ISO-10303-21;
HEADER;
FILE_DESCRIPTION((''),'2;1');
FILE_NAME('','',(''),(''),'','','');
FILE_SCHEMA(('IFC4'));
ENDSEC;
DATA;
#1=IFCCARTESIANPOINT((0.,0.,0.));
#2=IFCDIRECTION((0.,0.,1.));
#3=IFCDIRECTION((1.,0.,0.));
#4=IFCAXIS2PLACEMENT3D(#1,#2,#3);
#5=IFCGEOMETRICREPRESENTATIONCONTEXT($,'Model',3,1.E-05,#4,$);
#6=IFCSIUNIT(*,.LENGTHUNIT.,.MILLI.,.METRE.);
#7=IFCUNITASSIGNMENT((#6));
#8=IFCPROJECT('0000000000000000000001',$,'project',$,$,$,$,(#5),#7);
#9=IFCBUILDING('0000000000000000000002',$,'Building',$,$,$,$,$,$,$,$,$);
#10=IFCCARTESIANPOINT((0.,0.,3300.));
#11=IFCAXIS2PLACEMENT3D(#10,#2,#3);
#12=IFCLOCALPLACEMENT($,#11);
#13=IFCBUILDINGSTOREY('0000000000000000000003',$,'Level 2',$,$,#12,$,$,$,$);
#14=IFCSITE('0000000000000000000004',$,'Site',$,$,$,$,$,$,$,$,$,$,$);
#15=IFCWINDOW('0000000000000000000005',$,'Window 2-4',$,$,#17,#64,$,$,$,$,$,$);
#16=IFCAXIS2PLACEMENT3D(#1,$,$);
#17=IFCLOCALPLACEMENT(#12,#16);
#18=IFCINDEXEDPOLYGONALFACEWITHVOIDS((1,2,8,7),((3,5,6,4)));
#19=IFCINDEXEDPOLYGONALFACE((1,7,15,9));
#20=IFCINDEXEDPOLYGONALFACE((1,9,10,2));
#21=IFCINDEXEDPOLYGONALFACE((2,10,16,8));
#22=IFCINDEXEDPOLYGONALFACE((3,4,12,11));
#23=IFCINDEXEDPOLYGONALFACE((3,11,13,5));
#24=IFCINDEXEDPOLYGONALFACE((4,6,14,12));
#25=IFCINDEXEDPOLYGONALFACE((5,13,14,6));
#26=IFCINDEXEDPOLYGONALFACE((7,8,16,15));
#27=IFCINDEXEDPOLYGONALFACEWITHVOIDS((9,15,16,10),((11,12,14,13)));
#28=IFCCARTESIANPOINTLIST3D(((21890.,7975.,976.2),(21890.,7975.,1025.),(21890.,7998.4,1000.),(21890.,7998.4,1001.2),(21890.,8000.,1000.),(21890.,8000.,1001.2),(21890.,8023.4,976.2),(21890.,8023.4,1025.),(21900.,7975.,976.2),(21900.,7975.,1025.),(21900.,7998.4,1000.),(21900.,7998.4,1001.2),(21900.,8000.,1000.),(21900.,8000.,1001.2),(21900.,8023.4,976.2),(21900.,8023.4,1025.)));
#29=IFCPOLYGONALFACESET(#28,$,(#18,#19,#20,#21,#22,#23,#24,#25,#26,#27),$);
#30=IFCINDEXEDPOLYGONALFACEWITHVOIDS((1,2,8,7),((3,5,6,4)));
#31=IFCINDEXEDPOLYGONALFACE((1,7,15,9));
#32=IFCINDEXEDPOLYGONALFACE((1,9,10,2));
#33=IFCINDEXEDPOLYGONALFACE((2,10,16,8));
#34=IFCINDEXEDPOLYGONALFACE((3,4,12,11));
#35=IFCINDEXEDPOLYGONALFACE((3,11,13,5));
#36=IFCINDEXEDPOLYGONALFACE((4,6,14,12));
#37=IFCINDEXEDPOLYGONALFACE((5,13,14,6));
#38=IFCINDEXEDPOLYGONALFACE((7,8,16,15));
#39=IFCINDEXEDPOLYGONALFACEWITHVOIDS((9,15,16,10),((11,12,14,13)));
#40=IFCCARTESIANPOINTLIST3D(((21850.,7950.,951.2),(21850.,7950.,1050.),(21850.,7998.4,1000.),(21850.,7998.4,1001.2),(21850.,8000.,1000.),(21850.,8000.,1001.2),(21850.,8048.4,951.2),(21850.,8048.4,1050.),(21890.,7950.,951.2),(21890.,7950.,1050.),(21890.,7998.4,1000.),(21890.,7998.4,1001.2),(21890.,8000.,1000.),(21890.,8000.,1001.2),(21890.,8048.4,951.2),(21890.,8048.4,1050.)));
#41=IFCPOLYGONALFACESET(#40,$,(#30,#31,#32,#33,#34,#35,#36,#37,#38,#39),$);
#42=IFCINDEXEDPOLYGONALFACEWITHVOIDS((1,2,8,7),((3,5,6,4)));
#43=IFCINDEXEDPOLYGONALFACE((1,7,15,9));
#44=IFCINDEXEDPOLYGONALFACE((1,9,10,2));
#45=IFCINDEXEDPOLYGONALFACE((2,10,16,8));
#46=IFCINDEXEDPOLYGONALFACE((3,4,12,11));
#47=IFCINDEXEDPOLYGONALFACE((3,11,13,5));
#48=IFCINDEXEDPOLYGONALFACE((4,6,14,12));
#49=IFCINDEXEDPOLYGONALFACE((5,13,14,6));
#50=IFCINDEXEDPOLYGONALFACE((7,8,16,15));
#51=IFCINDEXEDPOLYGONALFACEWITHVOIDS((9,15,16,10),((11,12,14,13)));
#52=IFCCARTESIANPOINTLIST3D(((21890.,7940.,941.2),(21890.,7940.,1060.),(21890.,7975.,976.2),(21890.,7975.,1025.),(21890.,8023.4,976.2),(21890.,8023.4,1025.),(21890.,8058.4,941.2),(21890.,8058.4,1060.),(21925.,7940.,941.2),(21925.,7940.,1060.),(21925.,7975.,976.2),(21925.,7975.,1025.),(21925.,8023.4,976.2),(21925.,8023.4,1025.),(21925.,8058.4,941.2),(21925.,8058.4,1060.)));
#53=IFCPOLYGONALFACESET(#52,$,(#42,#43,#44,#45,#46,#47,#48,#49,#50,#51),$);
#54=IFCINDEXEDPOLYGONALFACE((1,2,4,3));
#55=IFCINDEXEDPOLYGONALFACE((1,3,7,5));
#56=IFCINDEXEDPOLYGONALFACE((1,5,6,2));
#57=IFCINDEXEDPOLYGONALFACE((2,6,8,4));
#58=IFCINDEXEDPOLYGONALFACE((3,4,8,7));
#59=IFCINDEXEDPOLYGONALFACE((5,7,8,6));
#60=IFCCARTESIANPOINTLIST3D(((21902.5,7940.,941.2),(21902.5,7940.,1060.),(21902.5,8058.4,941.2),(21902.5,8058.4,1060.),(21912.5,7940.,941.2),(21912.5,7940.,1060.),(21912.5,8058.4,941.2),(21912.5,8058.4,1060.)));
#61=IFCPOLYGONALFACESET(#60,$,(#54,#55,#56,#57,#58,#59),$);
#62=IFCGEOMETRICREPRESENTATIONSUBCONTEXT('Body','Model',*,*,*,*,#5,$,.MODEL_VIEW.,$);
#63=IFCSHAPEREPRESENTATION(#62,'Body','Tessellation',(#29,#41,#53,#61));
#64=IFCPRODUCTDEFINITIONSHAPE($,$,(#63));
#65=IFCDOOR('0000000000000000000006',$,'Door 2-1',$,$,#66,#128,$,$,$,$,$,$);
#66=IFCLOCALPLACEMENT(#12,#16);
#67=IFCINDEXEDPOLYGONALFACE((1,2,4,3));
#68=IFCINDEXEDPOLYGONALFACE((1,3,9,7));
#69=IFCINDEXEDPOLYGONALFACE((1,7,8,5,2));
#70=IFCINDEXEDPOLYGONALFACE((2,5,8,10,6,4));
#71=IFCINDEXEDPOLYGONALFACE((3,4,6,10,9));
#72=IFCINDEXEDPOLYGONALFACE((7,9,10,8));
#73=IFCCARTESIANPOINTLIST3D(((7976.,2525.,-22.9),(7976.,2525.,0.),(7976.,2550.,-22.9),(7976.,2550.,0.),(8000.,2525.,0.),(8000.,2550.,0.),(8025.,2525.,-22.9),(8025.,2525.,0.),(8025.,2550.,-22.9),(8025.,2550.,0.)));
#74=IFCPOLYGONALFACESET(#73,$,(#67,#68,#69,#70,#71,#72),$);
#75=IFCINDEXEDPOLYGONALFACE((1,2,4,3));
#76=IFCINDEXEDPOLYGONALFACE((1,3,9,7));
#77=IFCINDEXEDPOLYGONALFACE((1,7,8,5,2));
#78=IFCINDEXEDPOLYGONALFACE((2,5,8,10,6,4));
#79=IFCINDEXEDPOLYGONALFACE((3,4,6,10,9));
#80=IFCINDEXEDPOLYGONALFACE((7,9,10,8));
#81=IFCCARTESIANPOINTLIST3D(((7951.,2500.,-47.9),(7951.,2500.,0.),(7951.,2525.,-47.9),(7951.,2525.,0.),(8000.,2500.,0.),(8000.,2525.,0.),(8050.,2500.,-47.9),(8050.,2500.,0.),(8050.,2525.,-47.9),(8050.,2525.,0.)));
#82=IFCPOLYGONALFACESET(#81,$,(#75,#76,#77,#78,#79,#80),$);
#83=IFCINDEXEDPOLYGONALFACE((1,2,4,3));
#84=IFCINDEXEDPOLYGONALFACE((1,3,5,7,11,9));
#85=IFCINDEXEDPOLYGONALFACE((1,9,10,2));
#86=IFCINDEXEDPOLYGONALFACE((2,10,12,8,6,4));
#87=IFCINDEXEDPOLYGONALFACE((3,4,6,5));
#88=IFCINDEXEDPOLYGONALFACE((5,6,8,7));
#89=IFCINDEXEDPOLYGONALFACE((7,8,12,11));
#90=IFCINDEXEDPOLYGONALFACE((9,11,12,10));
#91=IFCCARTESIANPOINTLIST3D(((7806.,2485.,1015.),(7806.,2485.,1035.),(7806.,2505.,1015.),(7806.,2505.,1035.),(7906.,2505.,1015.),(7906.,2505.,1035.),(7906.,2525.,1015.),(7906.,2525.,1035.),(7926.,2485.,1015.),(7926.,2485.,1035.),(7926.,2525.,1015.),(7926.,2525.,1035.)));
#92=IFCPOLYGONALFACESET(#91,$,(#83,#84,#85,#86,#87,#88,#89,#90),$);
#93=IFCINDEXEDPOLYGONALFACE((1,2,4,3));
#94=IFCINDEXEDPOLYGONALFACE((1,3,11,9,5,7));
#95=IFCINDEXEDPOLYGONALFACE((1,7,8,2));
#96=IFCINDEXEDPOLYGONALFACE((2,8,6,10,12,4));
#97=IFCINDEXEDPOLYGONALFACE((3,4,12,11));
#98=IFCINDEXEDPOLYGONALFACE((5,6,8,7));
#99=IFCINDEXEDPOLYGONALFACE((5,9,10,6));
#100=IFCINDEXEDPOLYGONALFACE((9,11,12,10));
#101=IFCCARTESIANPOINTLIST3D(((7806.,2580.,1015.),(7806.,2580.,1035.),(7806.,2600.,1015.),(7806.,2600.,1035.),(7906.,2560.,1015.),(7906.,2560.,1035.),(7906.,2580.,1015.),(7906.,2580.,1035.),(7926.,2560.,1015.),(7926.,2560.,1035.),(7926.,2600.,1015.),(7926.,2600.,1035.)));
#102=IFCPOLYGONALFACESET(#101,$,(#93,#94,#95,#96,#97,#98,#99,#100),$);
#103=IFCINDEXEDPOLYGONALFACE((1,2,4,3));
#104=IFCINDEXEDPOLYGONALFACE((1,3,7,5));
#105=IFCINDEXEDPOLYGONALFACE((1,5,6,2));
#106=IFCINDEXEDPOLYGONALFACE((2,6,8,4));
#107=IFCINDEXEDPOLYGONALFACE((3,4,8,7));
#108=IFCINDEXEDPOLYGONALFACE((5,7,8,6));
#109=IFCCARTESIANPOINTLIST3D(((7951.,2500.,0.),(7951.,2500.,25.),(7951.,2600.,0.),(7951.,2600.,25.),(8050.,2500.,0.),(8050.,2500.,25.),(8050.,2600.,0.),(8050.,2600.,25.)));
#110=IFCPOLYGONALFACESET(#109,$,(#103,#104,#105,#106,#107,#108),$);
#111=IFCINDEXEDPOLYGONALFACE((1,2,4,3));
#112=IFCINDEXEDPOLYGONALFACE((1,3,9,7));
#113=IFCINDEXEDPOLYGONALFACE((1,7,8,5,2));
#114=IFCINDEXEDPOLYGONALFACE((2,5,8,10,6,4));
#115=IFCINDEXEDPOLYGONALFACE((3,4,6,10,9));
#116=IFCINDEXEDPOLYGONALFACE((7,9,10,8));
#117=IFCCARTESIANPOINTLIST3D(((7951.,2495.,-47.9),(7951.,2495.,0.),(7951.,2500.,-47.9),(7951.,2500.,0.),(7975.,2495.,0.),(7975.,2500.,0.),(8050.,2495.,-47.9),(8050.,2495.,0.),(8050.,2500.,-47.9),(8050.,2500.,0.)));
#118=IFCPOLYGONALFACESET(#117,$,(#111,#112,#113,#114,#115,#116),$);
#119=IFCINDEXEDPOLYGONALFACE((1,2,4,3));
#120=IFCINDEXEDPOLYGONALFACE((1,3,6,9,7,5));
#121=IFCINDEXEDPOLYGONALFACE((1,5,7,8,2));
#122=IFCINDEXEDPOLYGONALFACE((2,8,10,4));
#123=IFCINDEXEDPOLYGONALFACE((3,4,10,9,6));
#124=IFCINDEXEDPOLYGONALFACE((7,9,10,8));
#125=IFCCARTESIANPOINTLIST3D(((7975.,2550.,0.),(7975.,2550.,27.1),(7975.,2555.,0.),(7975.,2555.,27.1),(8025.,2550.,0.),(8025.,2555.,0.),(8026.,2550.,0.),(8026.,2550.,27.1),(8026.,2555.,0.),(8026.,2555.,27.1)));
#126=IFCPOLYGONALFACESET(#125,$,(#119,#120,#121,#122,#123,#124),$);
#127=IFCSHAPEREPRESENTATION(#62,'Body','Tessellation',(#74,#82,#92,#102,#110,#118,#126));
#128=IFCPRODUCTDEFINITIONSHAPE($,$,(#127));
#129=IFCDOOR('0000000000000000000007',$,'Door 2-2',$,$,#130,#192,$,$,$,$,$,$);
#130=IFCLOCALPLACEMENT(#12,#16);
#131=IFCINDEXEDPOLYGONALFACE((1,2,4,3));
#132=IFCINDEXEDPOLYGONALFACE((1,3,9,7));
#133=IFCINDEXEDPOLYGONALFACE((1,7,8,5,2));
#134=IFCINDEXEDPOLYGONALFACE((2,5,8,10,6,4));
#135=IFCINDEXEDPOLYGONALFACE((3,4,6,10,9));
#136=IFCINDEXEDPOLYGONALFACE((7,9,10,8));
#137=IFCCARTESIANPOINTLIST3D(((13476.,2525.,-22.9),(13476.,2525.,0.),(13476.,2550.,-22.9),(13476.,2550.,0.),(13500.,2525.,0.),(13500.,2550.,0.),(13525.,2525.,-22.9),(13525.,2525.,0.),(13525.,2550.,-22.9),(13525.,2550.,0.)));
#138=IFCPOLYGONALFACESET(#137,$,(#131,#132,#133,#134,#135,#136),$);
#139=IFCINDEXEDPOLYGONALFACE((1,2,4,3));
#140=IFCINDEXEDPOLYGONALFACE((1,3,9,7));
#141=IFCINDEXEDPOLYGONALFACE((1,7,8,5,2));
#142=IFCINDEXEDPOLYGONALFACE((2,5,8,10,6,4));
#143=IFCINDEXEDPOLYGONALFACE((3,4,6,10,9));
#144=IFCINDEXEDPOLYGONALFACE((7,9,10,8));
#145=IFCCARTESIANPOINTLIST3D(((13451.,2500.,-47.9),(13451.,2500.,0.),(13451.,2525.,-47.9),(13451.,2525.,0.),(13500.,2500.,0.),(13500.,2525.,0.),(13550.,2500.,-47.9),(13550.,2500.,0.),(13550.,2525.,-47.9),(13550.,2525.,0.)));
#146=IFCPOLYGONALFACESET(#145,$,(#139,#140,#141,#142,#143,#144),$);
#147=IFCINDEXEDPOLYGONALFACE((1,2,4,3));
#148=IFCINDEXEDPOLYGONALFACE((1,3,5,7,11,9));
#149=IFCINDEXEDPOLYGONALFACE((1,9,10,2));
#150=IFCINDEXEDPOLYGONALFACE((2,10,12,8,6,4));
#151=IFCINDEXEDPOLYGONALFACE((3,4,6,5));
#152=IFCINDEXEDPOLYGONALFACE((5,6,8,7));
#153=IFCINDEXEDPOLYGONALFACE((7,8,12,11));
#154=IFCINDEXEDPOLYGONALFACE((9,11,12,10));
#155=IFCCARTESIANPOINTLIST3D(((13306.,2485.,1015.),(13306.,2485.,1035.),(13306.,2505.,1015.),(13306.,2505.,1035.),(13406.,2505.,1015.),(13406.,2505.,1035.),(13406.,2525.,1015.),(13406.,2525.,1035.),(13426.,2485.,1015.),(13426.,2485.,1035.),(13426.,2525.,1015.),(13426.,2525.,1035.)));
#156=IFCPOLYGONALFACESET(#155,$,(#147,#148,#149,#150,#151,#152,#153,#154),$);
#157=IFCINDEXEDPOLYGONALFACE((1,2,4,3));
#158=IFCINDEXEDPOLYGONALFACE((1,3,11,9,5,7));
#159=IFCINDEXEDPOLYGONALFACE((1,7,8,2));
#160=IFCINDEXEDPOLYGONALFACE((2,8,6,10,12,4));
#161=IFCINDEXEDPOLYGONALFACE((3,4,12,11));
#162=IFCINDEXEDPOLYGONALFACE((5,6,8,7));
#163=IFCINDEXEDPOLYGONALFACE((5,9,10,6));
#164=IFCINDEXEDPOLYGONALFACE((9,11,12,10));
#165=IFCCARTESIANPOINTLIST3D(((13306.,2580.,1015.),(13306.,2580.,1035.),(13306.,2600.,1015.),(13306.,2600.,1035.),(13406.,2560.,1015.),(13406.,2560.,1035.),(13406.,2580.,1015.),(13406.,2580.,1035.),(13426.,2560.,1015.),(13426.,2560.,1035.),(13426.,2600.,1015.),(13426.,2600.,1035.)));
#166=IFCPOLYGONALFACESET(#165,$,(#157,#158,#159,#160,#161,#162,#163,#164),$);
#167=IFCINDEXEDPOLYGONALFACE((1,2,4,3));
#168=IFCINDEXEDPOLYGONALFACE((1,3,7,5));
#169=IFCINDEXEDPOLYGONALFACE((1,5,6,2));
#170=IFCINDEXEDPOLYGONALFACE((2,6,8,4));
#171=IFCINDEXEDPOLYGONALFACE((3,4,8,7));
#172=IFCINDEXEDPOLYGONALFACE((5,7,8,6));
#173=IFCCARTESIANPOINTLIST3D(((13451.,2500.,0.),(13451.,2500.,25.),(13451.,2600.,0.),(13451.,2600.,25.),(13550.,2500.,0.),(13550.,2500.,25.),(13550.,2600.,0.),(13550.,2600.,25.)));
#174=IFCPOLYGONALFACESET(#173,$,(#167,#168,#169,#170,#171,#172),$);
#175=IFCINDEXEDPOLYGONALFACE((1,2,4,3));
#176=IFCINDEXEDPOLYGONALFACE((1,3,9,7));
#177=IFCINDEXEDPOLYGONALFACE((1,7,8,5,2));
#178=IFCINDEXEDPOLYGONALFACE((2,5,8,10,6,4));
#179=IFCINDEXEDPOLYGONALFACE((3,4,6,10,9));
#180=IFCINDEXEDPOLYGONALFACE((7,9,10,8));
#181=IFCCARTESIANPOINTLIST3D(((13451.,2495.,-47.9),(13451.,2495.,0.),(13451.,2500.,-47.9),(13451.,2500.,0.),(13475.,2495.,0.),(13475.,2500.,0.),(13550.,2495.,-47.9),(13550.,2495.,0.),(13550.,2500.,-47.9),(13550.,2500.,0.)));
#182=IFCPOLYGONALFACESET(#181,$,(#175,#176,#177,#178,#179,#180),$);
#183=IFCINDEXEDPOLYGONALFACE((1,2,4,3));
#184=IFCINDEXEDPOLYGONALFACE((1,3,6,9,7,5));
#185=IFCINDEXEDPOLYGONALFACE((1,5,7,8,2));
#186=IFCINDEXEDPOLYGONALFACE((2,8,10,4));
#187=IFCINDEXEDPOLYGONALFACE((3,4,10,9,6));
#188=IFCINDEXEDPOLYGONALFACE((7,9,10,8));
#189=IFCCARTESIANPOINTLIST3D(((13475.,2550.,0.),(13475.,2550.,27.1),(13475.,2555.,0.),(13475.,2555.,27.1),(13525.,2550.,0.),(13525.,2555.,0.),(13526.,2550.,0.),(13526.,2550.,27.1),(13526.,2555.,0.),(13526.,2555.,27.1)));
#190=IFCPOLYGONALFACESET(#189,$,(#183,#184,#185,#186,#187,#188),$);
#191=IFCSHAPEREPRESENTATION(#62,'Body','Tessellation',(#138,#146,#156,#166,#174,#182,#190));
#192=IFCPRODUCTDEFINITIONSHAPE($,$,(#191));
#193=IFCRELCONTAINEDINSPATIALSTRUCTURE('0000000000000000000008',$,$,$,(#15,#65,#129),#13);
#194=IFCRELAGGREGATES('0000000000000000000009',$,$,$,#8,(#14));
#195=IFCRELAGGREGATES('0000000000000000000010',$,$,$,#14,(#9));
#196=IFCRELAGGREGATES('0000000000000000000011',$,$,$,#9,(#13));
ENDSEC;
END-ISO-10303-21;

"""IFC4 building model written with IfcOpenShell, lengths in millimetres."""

from ifc_helpers import new_model, si_unit, frame, origin_with_axes, place, context, subcontext, project, spatial, line, indexed_curve, outline, extrude, element, save


model = new_model("IFC4")

# Units and contexts
model_context = context("Model", 3, precision=1e-05, world=origin_with_axes())
body_context = subcontext(model_context, "Body", "Model", "MODEL_VIEW")
ifc_project = project(units=[si_unit("LENGTHUNIT", "METRE", prefix="MILLI")], contexts=[model_context])

# Site, building, storey
site = spatial("IfcSite", under=ifc_project, Name="Site")
building = spatial("IfcBuilding", under=site, Name="Building")
storey_placement = place(None, frame((0.0, 0.0, 3300.0), z_axis=(0.0, 0.0, 1.0), x_axis=(1.0, 0.0, 0.0)))
storey = spatial("IfcBuildingStorey", under=building, at=storey_placement, Name="Level 2")

# Window
for number, where, z_axis, x_axis, name in (
    (1, (21800.0, 8000.0, 1000.0), (0.0, 0.0, 1.0), (0.0, -1.0, 0.0), "Window 2-4"),
):
    element("IfcWindow", number, at=place(storey_placement, frame(where, z_axis=z_axis, x_axis=x_axis)), inside=storey, Name=name, context=body_context, shape_type="SweptSolid", body=[
        extrude(outline(indexed_curve([(0.0, 0.0), (1.6, 0.0), (1.6, 1.2), (0.0, 1.2)], segments=[line(1, 2, 3, 4, 1)]), holes=[indexed_curve([(25.0, 25.0), (-23.4, 25.0), (-23.4, -23.8), (25.0, -23.8)], segments=[line(1, 2, 3, 4, 1)])]), frame((0.0, 90.0, 0.0), z_axis=(0.0, -1.0, 0.0), x_axis=(1.0, 0.0, 0.0)), (0.0, 0.0, -1.0), 10.0),
        extrude(outline(indexed_curve([(0.0, 0.0), (1.6, 0.0), (1.6, 1.2), (0.0, 1.2)], segments=[line(1, 2, 3, 4, 1)]), holes=[indexed_curve([(50.0, 50.0), (-48.4, 50.0), (-48.4, -48.8), (50.0, -48.8)], segments=[line(1, 2, 3, 4, 1)])]), frame((0.0, 50.0, 0.0), z_axis=(0.0, -1.0, 0.0), x_axis=(1.0, 0.0, 0.0)), (0.0, 0.0, -1.0), 40.0),
        extrude(outline(indexed_curve([(0.0, 0.0), (-48.4, 0.0), (-48.4, -48.8), (0.0, -48.8)], segments=[line(1, 2, 3, 4, 1)]), holes=[indexed_curve([(35.0, 35.0), (-83.4, 35.0), (-83.4, -83.8), (35.0, -83.8)], segments=[line(1, 2, 3, 4, 1)])]), frame((25.0, 90.0, 25.0), z_axis=(0.0, -1.0, 0.0), x_axis=(1.0, 0.0, 0.0)), (0.0, 0.0, -1.0), 35.0),
        extrude(outline(indexed_curve([(35.0, 35.0), (-83.4, 35.0), (-83.4, -83.8), (35.0, -83.8)], segments=[line(1, 2, 3, 4, 1)])), frame((25.0, 102.5, 25.0), z_axis=(0.0, -1.0, 0.0), x_axis=(1.0, 0.0, 0.0)), (0.0, 0.0, -1.0), 10.0),
    ])

# Doors
door_1_placement = place(storey_placement, frame((8000.0, 2500.0, 0.0), z_axis=(0.0, 0.0, 1.0), x_axis=(1.0, 0.0, 0.0)))
element("IfcDoor", 2, at=door_1_placement, inside=storey, Name="Door 2-1", context=body_context, shape_type="SweptSolid", body=[
    extrude(outline(indexed_curve([(0.0, 0.0), (0.0, 2.1), (1.0, 2.1), (1.0, 0.0), (-24.0, 0.0), (-24.0, -22.9), (25.0, -22.9), (25.0, 0.0)], segments=[line(1, 2, 3, 4, 5, 6, 7, 8, 1)])), frame((0.0, 25.0, 0.0), z_axis=(0.0, -1.0, 0.0), x_axis=(1.0, 0.0, 0.0)), (0.0, 0.0, -1.0), 25.0),
    extrude(outline(indexed_curve([(0.0, 0.0), (0.0, 2.1), (1.0, 2.1), (1.0, 0.0), (-49.0, 0.0), (-49.0, -47.9), (50.0, -47.9), (50.0, 0.0)], segments=[line(1, 2, 3, 4, 5, 6, 7, 8, 1)])), frame((0.0, 0.0, 0.0), z_axis=(0.0, -1.0, 0.0), x_axis=(1.0, 0.0, 0.0)), (0.0, 0.0, -1.0), 25.0),
    extrude(outline(indexed_curve([(0.0, 0.0), (-49.0, 0.0), (-49.0, 35.0), (0.0, 35.0)], segments=[line(1, 2, 3, 4, 1)])), frame((25.0, 25.0, 25.0), z_axis=(0.0, 0.0, 1.0), x_axis=(1.0, 0.0, 0.0)), (0.0, 0.0, 1.0), -47.9),
    extrude(outline(indexed_curve([(0.0, 0.0), (0.0, -40.0), (-120.0, -40.0), (-120.0, -20.0), (-20.0, -20.0), (-20.0, 0.0)], segments=[line(1, 2, 3, 4, 5, 6, 1)])), frame((-74.0, 25.0, 1015.0), z_axis=(0.0, 0.0, 1.0), x_axis=(1.0, 0.0, 0.0)), (0.0, 0.0, 1.0), 20.0),
    extrude(outline(indexed_curve([(0.0, 0.0), (0.0, 40.0), (-120.0, 40.0), (-120.0, 20.0), (-20.0, 20.0), (-20.0, 0.0)], segments=[line(1, 2, 3, 4, 5, 6, 1)])), frame((-74.0, 60.0, 1015.0), z_axis=(0.0, 0.0, 1.0), x_axis=(1.0, 0.0, 0.0)), (0.0, 0.0, 1.0), 20.0),
    extrude(outline(indexed_curve([(0.0, 0.0), (-99.0, 0.0), (-99.0, 100.0), (0.0, 100.0)], segments=[line(1, 2, 3, 4, 1)])), frame((50.0, 0.0, 0.0), z_axis=(0.0, 0.0, 1.0), x_axis=(1.0, 0.0, 0.0)), (0.0, 0.0, 1.0), 25.0),
    extrude(outline(indexed_curve([(0.0, 0.0), (0.0, 27.1), (51.0, 27.1), (51.0, 0.0), (-24.0, 0.0), (-24.0, -47.9), (75.0, -47.9), (75.0, 0.0)], segments=[line(1, 2, 3, 4, 5, 6, 7, 8, 1)])), frame((-25.0, -5.0, 0.0), z_axis=(0.0, -1.0, 0.0), x_axis=(1.0, 0.0, 0.0)), (0.0, 0.0, -1.0), 5.0),
    extrude(outline(indexed_curve([(0.0, 0.0), (0.0, 27.1), (51.0, 27.1), (51.0, 0.0), (1.0, 0.0), (1.0, -22.9), (50.0, -22.9), (50.0, 0.0)], segments=[line(1, 2, 3, 4, 5, 6, 7, 8, 1)])), frame((-25.0, 50.0, 0.0), z_axis=(0.0, -1.0, 0.0), x_axis=(1.0, 0.0, 0.0)), (0.0, 0.0, -1.0), 5.0),
])
door_2_placement = place(storey_placement, frame((13500.0, 2500.0, 0.0), z_axis=(0.0, 0.0, 1.0), x_axis=(1.0, 0.0, 0.0)))
element("IfcDoor", 3, at=door_2_placement, inside=storey, Name="Door 2-2", context=body_context, shape_type="SweptSolid", body=[
    extrude(outline(indexed_curve([(0.0, 0.0), (0.0, 2.1), (1.0, 2.1), (1.0, 0.0), (-24.0, 0.0), (-24.0, -22.9), (25.0, -22.9), (25.0, 0.0)], segments=[line(1, 2, 3, 4, 5, 6, 7, 8, 1)])), frame((0.0, 25.0, 0.0), z_axis=(0.0, -1.0, 0.0), x_axis=(1.0, 0.0, 0.0)), (0.0, 0.0, -1.0), 25.0),
    extrude(outline(indexed_curve([(0.0, 0.0), (0.0, 2.1), (1.0, 2.1), (1.0, 0.0), (-49.0, 0.0), (-49.0, -47.9), (50.0, -47.9), (50.0, 0.0)], segments=[line(1, 2, 3, 4, 5, 6, 7, 8, 1)])), frame((0.0, 0.0, 0.0), z_axis=(0.0, -1.0, 0.0), x_axis=(1.0, 0.0, 0.0)), (0.0, 0.0, -1.0), 25.0),
    extrude(outline(indexed_curve([(0.0, 0.0), (-49.0, 0.0), (-49.0, 35.0), (0.0, 35.0)], segments=[line(1, 2, 3, 4, 1)])), frame((25.0, 25.0, 25.0), z_axis=(0.0, 0.0, 1.0), x_axis=(1.0, 0.0, 0.0)), (0.0, 0.0, 1.0), -47.9),
    extrude(outline(indexed_curve([(0.0, 0.0), (0.0, -40.0), (-120.0, -40.0), (-120.0, -20.0), (-20.0, -20.0), (-20.0, 0.0)], segments=[line(1, 2, 3, 4, 5, 6, 1)])), frame((-74.0, 25.0, 1015.0), z_axis=(0.0, 0.0, 1.0), x_axis=(1.0, 0.0, 0.0)), (0.0, 0.0, 1.0), 20.0),
    extrude(outline(indexed_curve([(0.0, 0.0), (0.0, 40.0), (-120.0, 40.0), (-120.0, 20.0), (-20.0, 20.0), (-20.0, 0.0)], segments=[line(1, 2, 3, 4, 5, 6, 1)])), frame((-74.0, 60.0, 1015.0), z_axis=(0.0, 0.0, 1.0), x_axis=(1.0, 0.0, 0.0)), (0.0, 0.0, 1.0), 20.0),
    extrude(outline(indexed_curve([(0.0, 0.0), (-99.0, 0.0), (-99.0, 100.0), (0.0, 100.0)], segments=[line(1, 2, 3, 4, 1)])), frame((50.0, 0.0, 0.0), z_axis=(0.0, 0.0, 1.0), x_axis=(1.0, 0.0, 0.0)), (0.0, 0.0, 1.0), 25.0),
    extrude(outline(indexed_curve([(0.0, 0.0), (0.0, 27.1), (51.0, 27.1), (51.0, 0.0), (-24.0, 0.0), (-24.0, -47.9), (75.0, -47.9), (75.0, 0.0)], segments=[line(1, 2, 3, 4, 5, 6, 7, 8, 1)])), frame((-25.0, -5.0, 0.0), z_axis=(0.0, -1.0, 0.0), x_axis=(1.0, 0.0, 0.0)), (0.0, 0.0, -1.0), 5.0),
    extrude(outline(indexed_curve([(0.0, 0.0), (0.0, 27.1), (51.0, 27.1), (51.0, 0.0), (1.0, 0.0), (1.0, -22.9), (50.0, -22.9), (50.0, 0.0)], segments=[line(1, 2, 3, 4, 5, 6, 7, 8, 1)])), frame((-25.0, 50.0, 0.0), z_axis=(0.0, -1.0, 0.0), x_axis=(1.0, 0.0, 0.0)), (0.0, 0.0, -1.0), 5.0),
])

save(model, "model.ifc")
